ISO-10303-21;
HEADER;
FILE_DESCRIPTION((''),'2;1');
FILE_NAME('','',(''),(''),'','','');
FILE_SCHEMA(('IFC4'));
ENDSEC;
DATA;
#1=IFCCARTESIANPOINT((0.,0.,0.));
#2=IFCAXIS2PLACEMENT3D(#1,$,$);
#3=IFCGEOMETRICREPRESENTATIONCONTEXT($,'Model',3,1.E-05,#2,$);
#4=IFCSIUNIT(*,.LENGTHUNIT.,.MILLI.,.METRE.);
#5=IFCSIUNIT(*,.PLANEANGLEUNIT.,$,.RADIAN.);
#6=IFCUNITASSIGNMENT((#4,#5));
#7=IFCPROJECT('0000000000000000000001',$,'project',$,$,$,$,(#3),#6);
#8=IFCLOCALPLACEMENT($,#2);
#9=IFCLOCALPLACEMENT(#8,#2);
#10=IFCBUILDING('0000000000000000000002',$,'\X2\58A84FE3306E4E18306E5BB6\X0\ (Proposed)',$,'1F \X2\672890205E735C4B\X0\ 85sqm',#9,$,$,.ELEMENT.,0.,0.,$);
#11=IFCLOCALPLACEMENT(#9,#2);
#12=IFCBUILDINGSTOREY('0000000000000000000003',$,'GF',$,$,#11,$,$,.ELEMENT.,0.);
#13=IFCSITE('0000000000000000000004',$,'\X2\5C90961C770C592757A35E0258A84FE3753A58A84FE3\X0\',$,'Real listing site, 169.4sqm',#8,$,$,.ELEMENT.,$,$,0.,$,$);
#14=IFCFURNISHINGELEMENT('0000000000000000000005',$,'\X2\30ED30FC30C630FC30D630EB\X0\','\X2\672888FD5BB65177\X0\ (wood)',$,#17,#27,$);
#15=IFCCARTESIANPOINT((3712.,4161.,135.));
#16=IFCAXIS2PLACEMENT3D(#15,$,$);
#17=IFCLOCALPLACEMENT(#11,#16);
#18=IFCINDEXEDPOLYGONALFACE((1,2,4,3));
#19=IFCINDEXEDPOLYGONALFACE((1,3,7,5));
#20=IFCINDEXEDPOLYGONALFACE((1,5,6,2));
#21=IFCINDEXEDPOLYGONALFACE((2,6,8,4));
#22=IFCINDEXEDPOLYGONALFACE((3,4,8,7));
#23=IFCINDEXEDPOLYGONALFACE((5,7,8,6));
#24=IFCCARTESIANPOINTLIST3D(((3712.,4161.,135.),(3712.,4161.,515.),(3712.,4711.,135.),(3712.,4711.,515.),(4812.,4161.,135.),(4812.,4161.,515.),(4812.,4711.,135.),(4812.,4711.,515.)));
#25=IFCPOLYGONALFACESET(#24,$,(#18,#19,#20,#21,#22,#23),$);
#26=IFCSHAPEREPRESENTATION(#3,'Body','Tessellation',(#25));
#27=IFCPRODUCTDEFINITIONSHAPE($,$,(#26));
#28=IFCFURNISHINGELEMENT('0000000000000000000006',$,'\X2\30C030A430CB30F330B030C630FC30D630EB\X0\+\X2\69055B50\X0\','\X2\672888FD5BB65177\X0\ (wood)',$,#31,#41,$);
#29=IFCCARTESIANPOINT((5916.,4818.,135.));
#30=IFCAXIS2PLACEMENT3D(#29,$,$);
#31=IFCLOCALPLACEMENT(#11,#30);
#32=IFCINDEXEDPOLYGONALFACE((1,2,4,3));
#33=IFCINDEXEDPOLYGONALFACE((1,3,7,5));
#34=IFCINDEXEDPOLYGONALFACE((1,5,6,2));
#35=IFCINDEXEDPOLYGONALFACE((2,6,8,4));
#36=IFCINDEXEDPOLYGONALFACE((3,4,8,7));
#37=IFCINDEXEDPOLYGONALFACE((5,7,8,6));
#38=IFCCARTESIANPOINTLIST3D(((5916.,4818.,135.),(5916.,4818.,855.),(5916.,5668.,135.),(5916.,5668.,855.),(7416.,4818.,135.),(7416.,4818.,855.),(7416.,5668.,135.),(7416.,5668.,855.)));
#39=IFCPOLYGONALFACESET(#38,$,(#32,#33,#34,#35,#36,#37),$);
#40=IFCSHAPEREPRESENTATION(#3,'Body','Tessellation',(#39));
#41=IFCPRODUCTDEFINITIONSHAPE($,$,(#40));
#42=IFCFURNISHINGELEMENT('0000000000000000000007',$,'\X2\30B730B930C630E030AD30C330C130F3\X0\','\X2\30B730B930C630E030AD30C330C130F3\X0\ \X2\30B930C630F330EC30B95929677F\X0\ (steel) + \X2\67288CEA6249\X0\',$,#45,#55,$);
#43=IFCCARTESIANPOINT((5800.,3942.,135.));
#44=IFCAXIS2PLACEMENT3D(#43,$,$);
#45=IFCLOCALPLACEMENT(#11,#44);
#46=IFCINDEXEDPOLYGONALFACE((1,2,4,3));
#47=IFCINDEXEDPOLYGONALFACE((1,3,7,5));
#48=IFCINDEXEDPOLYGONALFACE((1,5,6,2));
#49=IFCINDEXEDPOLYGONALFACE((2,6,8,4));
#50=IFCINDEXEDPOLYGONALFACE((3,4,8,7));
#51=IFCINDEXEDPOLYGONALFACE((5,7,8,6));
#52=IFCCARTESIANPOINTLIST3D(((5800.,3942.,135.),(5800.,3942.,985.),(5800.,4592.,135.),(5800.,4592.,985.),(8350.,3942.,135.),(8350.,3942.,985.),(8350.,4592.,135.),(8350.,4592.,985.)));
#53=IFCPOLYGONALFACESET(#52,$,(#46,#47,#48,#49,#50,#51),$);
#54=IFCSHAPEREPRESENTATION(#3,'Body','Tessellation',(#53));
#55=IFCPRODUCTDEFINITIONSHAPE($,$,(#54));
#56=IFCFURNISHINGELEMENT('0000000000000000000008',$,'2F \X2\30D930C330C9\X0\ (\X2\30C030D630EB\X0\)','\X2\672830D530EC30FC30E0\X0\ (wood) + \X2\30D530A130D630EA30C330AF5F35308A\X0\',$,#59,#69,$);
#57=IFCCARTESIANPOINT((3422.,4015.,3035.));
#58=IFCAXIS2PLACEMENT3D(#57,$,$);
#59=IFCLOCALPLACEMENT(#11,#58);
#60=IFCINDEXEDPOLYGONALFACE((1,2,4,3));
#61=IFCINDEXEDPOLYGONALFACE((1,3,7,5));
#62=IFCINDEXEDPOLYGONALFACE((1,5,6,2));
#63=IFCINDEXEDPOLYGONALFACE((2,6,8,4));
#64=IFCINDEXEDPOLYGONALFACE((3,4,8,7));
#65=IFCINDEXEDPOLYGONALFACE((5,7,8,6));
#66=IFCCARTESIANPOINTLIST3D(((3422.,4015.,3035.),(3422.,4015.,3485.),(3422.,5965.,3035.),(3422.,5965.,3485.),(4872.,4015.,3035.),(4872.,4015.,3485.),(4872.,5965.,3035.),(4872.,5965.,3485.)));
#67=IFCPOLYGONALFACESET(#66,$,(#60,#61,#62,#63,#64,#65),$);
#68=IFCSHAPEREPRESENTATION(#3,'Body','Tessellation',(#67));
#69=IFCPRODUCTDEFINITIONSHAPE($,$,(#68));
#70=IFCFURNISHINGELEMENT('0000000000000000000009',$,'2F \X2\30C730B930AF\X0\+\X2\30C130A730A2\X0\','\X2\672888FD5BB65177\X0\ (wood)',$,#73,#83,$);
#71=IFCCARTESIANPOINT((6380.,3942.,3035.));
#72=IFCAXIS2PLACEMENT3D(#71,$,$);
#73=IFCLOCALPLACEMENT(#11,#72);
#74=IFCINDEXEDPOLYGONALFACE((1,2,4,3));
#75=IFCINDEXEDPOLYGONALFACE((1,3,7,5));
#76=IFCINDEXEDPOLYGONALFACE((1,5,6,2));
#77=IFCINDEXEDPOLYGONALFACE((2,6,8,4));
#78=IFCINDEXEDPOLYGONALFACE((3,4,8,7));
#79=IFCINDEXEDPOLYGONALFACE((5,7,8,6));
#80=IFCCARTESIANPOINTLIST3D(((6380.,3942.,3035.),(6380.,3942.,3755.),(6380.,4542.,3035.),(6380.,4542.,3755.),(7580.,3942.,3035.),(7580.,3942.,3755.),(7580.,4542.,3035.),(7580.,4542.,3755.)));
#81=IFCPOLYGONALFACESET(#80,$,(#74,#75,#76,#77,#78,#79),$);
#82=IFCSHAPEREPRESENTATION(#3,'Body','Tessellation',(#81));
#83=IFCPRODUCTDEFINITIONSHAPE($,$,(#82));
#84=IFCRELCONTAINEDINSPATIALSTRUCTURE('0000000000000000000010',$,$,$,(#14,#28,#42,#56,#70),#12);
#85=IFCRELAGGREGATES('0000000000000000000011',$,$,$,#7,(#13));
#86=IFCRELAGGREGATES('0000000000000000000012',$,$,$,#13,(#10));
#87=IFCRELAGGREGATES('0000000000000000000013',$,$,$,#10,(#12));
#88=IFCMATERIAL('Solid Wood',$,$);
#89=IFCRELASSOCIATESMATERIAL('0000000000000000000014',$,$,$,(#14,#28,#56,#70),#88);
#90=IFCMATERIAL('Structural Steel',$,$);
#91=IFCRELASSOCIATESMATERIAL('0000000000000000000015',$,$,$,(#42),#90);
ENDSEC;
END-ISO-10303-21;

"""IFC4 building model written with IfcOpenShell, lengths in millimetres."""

from ifc_helpers import new_model, si_unit, frame, frame_2d, origin, place, context, project, spatial, rectangle, extrude, material, element, save


model = new_model("IFC4")

# Units and contexts
model_context = context("Model", 3, precision=1e-05, world=origin())
ifc_project = project(units=[si_unit("LENGTHUNIT", "METRE", prefix="MILLI"), si_unit("PLANEANGLEUNIT", "RADIAN")], contexts=[model_context])

# Site, building, storey
site_placement = place(None, origin())
site = spatial("IfcSite", under=ifc_project, at=site_placement, Name="岐阜県大垣市墨俣町墨俣", ObjectType="Real listing site, 169.4sqm", CompositionType="ELEMENT", RefElevation=0.0)
building_placement = place(site_placement, origin())
building = spatial("IfcBuilding", under=site, at=building_placement, Name="墨俣の丘の家 (Proposed)", ObjectType="1F 木造平屋 85sqm", CompositionType="ELEMENT", ElevationOfRefHeight=0.0, ElevationOfTerrain=0.0)
storey_placement = place(building_placement, origin())
storey = spatial("IfcBuildingStorey", under=building, at=storey_placement, Name="GF", CompositionType="ELEMENT", Elevation=0.0)

# Shared definitions
ifc_material_1 = material(Name="Solid Wood")

# Shared definitions
ifc_material_2 = material(Name="Structural Steel")

# Furnishing elements
furnishing_1_placement = place(storey_placement, frame((3712.0, 4161.0, 135.0)))
element("IfcFurnishingElement", 1, at=furnishing_1_placement, inside=storey, material=ifc_material_1, Name="ローテーブル", Description="木製家具 (wood)", context=model_context, shape_type="SweptSolid", body=[
    extrude(rectangle(XDim=1100.0, YDim=550.0, at=frame_2d((550.0, 275.0))), frame((3712.0, 4161.0, 135.0)), (0.0, 0.0, 1.0), 380.0),
])
furnishing_2_placement = place(storey_placement, frame((5916.0, 4818.0, 135.0)))
element("IfcFurnishingElement", 2, at=furnishing_2_placement, inside=storey, material=ifc_material_1, Name="ダイニングテーブル+椅子", Description="木製家具 (wood)", context=model_context, shape_type="SweptSolid", body=[
    extrude(rectangle(XDim=1500.0, YDim=850.0, at=frame_2d((750.0, 425.0))), frame((5916.0, 4818.0, 135.0)), (0.0, 0.0, 1.0), 720.0),
])
furnishing_3_placement = place(storey_placement, frame((5800.0, 3942.0, 135.0)))
element("IfcFurnishingElement", 3, at=furnishing_3_placement, inside=storey, material=ifc_material_2, Name="システムキッチン", Description="システムキッチン ステンレス天板 (steel) + 木質扉", context=model_context, shape_type="SweptSolid", body=[
    extrude(rectangle(XDim=2550.0, YDim=650.0, at=frame_2d((1275.0, 325.0))), frame((5800.0, 3942.0, 135.0)), (0.0, 0.0, 1.0), 850.0),
])
furnishing_4_placement = place(storey_placement, frame((3422.0, 4015.0, 3035.0)))
element("IfcFurnishingElement", 4, at=furnishing_4_placement, inside=storey, material=ifc_material_1, Name="2F ベッド (ダブル)", Description="木フレーム (wood) + ファブリック張り", context=model_context, shape_type="SweptSolid", body=[
    extrude(rectangle(XDim=1450.0, YDim=1950.0, at=frame_2d((725.0, 975.0))), frame((3422.0, 4015.0, 3035.0)), (0.0, 0.0, 1.0), 450.0),
])
furnishing_5_placement = place(storey_placement, frame((6380.0, 3942.0, 3035.0)))
element("IfcFurnishingElement", 5, at=furnishing_5_placement, inside=storey, material=ifc_material_1, Name="2F デスク+チェア", Description="木製家具 (wood)", context=model_context, shape_type="SweptSolid", body=[
    extrude(rectangle(XDim=1200.0, YDim=600.0, at=frame_2d((600.0, 300.0))), frame((6380.0, 3942.0, 3035.0)), (0.0, 0.0, 1.0), 720.0),
])

save(model, "model.ifc")
